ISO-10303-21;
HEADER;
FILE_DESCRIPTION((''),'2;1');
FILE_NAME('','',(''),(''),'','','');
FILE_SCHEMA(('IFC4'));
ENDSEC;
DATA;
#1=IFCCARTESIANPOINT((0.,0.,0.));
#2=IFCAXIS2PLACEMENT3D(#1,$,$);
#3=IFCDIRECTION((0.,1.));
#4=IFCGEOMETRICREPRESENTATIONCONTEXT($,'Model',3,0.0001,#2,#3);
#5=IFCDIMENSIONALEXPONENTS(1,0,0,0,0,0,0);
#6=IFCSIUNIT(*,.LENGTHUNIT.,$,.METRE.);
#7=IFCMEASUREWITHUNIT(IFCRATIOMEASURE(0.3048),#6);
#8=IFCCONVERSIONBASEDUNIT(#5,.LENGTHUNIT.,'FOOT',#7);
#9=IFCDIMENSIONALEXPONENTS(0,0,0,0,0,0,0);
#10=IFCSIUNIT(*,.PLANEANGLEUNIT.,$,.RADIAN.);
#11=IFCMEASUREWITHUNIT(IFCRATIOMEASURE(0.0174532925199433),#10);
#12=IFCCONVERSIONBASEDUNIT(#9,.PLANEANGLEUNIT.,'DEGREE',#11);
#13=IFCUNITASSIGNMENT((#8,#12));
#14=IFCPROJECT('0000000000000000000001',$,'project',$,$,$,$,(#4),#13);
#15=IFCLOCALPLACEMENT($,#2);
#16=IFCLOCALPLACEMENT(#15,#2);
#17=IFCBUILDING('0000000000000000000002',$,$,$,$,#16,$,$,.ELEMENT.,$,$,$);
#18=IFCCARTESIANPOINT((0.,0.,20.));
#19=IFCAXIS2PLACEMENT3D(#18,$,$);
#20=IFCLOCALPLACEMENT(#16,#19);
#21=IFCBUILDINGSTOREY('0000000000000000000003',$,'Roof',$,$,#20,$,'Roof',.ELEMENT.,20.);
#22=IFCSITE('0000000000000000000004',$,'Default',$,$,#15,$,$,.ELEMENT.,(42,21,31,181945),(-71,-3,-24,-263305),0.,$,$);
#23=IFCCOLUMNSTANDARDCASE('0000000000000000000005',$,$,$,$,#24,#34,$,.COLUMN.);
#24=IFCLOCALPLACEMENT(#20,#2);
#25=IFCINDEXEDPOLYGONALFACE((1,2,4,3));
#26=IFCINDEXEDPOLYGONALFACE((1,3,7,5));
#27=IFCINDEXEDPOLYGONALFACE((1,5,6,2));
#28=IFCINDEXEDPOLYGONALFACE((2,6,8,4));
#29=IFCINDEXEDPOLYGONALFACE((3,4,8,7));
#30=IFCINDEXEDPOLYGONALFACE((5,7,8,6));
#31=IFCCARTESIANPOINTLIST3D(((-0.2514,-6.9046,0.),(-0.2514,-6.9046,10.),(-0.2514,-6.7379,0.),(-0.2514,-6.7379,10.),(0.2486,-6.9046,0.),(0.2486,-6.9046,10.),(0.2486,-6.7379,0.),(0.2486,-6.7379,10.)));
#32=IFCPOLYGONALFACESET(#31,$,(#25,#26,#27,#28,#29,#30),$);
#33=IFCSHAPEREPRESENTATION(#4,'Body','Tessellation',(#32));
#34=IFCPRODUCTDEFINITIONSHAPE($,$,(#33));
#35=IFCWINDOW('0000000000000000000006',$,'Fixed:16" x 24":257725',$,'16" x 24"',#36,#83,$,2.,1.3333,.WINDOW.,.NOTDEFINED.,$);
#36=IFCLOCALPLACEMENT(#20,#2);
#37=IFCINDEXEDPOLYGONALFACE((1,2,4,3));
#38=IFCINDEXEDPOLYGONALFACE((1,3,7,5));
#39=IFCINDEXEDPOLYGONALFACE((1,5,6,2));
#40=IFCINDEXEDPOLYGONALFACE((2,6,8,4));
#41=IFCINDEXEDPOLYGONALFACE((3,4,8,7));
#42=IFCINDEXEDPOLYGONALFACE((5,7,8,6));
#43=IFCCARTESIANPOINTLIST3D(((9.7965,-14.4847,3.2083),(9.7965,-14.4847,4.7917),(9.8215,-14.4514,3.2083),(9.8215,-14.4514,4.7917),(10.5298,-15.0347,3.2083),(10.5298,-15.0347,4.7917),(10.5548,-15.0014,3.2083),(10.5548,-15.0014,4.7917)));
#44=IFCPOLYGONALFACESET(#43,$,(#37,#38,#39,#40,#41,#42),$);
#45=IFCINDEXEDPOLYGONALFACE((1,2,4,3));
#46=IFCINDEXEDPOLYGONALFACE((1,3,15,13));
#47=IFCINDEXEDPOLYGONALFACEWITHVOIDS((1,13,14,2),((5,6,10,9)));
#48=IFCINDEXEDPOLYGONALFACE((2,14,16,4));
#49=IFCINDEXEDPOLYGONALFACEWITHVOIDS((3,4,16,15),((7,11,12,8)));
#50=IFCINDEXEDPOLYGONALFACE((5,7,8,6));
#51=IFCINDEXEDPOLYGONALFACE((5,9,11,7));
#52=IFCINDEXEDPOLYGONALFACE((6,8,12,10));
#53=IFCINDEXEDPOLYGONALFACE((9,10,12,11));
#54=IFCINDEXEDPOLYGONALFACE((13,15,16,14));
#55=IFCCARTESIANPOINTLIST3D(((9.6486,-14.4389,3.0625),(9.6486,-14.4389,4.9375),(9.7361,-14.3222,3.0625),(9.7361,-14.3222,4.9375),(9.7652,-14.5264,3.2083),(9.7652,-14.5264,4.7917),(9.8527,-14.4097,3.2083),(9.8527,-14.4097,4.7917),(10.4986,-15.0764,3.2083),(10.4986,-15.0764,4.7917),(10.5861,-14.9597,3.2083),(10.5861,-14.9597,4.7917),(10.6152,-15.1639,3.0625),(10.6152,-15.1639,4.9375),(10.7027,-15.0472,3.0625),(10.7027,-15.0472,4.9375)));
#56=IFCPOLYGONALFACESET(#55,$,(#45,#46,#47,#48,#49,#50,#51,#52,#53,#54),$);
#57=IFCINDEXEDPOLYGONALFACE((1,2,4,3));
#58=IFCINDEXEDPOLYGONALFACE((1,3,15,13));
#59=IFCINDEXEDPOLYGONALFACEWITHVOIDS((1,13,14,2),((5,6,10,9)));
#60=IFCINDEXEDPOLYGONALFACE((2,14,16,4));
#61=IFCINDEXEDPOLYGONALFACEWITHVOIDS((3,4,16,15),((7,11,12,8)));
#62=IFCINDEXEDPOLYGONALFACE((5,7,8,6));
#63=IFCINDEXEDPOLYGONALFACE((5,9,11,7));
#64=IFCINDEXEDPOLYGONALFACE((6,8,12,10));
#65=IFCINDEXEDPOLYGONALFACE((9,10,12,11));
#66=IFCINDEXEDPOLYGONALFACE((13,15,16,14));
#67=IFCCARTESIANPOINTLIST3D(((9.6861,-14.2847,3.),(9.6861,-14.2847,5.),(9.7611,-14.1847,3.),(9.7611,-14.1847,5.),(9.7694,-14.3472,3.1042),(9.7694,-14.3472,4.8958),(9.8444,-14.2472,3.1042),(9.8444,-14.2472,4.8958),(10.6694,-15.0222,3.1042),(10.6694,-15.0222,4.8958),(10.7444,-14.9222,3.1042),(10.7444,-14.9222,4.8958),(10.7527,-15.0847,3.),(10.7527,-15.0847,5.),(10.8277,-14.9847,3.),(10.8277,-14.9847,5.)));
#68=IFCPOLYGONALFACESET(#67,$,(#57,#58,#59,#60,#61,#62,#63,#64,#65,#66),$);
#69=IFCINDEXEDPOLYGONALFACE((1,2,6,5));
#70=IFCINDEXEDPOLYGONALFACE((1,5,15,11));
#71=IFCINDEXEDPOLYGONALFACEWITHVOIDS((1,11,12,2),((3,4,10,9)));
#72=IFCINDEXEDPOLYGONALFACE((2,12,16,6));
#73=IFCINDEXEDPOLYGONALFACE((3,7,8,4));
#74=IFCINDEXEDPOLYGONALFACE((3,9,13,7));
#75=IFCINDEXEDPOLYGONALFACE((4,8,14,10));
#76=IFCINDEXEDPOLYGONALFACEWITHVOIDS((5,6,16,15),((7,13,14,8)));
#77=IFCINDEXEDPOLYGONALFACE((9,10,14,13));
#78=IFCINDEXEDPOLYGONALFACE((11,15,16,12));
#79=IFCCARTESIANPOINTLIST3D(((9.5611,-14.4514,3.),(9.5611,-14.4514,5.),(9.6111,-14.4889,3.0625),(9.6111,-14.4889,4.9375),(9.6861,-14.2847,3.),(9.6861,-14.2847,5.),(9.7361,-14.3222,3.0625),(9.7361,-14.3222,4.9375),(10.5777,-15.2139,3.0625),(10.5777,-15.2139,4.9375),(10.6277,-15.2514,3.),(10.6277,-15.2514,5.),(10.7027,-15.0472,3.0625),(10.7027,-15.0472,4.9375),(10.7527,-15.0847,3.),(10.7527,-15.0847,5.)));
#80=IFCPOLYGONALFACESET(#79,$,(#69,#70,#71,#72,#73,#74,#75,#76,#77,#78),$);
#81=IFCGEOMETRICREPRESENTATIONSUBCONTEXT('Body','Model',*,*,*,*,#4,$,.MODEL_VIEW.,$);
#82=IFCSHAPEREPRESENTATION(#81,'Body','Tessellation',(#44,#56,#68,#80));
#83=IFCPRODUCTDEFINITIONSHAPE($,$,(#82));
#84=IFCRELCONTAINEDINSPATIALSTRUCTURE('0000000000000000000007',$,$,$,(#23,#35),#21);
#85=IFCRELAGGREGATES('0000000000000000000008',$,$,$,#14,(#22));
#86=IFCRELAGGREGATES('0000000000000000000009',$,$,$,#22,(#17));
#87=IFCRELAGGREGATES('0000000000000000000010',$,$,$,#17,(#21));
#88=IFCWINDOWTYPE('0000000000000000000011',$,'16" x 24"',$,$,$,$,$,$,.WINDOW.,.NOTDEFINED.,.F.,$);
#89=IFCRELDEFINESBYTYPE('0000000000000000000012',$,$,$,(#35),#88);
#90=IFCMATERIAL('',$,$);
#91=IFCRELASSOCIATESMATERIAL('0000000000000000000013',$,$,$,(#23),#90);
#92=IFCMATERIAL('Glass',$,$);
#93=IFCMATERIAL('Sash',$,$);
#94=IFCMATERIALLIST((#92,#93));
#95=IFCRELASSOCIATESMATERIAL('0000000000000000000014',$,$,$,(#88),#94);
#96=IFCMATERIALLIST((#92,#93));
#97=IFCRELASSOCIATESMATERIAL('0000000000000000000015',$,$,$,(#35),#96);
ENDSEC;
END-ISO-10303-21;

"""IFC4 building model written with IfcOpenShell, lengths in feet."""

from ifc_helpers import new_model, entity, si_unit, converted_unit, direction, frame, origin, origin_2d_with_axis, place, context, subcontext, project, spatial, polyline, rectangle, outline, extrude, source, transform, mapped, material, material_list, type_object, type_shapes, element, save


model = new_model("IFC4")

# Units and contexts
model_context = context("Model", 3, precision=0.0001, world=origin(), true_north=direction((0.0, 1.0)))
body_context = subcontext(model_context, "Body", "Model", "MODEL_VIEW")
ifc_project = project(units=[converted_unit("LENGTHUNIT", "FOOT", entity("IfcRatioMeasure", 0.3048), si_unit("LENGTHUNIT", "METRE"), dimensions=[1, 0, 0, 0, 0, 0, 0]), converted_unit("PLANEANGLEUNIT", "DEGREE", entity("IfcRatioMeasure", 0.0174532925199433), si_unit("PLANEANGLEUNIT", "RADIAN"), dimensions=[0, 0, 0, 0, 0, 0, 0])], contexts=[model_context])

# Site, building, storey
site_placement = place(None, origin())
site = spatial("IfcSite", under=ifc_project, at=site_placement, Name="Default", CompositionType="ELEMENT", RefLatitude=(42, 21, 31, 181945), RefLongitude=(-71, -3, -24, -263305), RefElevation=0.0)
building_placement = place(site_placement, origin())
building = spatial("IfcBuilding", under=site, at=building_placement, CompositionType="ELEMENT")
storey_placement = place(building_placement, frame((0.0, 0.0, 20.0)))
storey = spatial("IfcBuildingStorey", under=building, at=storey_placement, Name="Roof", LongName="Roof", CompositionType="ELEMENT", Elevation=20.0)

# Column
ifc_material_1 = material(Name="")
placement_1 = place(storey_placement, frame((-0.0014, -6.9045, 0.0), z_axis=(0.0, 0.0, 1.0), x_axis=(0.0, 1.0, 0.0)))
for number, where, z_axis, x_axis in (
    (1, (0.0833, 0.0, 0.0), (0.0, 0.0, 1.0), (1.0, 0.0, 0.0)),
):
    element("IfcColumnStandardCase", number, at=place(placement_1, frame(where, z_axis=z_axis, x_axis=x_axis)), inside=storey, material=ifc_material_1, PredefinedType="COLUMN", context=model_context, shape_type="SweptSolid", body=[
        extrude(rectangle(XDim=0.1667, YDim=0.5), origin(), (0.0, 0.0, 1.0), 10.0),
    ])

# Window
ifc_material_2 = material(Name="Glass")
ifc_material_3 = material(Name="Sash")
ifc_material_list_1 = material_list([ifc_material_2, ifc_material_3])
ifc_material_list_2 = material_list([ifc_material_2, ifc_material_3])
window_type = type_object("IfcWindowType", Name="16\" x 24\"", ParameterTakesPrecedence=False, PartitioningType="NOTDEFINED", PredefinedType="WINDOW", material=ifc_material_list_2)
shared_shape = source(origin(), body_context, "Body", "SweptSolid", [
    extrude(rectangle(XDim=0.0417, YDim=0.9167, at=origin_2d_with_axis()), frame((0.6667, 0.1979, 0.2083), z_axis=(0.0, 0.0, 1.0), x_axis=(0.0, 1.0, 0.0)), (0.0, 0.0, 1.0), 1.5833),
    extrude(outline(polyline([(-0.6042, -0.9375), (0.6042, -0.9375), (0.6042, 0.9375), (-0.6042, 0.9375), (-0.6042, -0.9375)]), holes=[polyline([(-0.4583, -0.7917), (-0.4583, 0.7917), (0.4583, 0.7917), (0.4583, -0.7917), (-0.4583, -0.7917)])]), frame((0.6667, 0.125, 1.0), z_axis=(0.0, 1.0, 0.0), x_axis=(1.0, 0.0, 0.0)), (0.0, 0.0, 1.0), 0.1458),
    extrude(outline(polyline([(-0.6667, -1.0), (0.6667, -1.0), (0.6667, 1.0), (-0.6667, 1.0), (-0.6667, -1.0)]), holes=[polyline([(-0.5625, -0.8958), (-0.5625, 0.8958), (0.5625, 0.8958), (0.5625, -0.8958), (-0.5625, -0.8958)])]), frame((0.6667, 0.0, 1.0), z_axis=(0.0, 1.0, 0.0), x_axis=(1.0, 0.0, 0.0)), (0.0, 0.0, 1.0), 0.125),
    extrude(outline(polyline([(-1.0, -0.6667), (1.0, -0.6667), (1.0, 0.6667), (-1.0, 0.6667), (-1.0, -0.6667)]), holes=[polyline([(-0.9375, -0.6042), (-0.9375, 0.6042), (0.9375, 0.6042), (0.9375, -0.6042), (-0.9375, -0.6042)])]), frame((0.6667, 0.125, 1.0), z_axis=(0.0, 1.0, 0.0), x_axis=(0.0, 0.0, -1.0)), (0.0, 0.0, 1.0), 0.2083),
])
type_shapes(window_type, [shared_shape])
placement_2 = place(storey_placement, frame((47.9059, -43.0017, 0.0), z_axis=(0.0, 0.0, 1.0), x_axis=(-0.8, 0.6, 0.0)))
placement_3 = place(placement_2, frame((46.4728, -0.1667, 3.0)))
window_placement = place(placement_3, origin())
element("IfcWindow", 2, at=window_placement, inside=storey, type_object=window_type, material=ifc_material_list_1, Name="Fixed:16\" x 24\":257725", ObjectType="16\" x 24\"", OverallHeight=2.0, OverallWidth=1.3333, PartitioningType="NOTDEFINED", PredefinedType="WINDOW", context=body_context, shape_type="MappedRepresentation", body=[
    mapped(shared_shape, transform((0.0, 0.0, 0.0), scale=1.0)),
])

save(model, "model.ifc")
